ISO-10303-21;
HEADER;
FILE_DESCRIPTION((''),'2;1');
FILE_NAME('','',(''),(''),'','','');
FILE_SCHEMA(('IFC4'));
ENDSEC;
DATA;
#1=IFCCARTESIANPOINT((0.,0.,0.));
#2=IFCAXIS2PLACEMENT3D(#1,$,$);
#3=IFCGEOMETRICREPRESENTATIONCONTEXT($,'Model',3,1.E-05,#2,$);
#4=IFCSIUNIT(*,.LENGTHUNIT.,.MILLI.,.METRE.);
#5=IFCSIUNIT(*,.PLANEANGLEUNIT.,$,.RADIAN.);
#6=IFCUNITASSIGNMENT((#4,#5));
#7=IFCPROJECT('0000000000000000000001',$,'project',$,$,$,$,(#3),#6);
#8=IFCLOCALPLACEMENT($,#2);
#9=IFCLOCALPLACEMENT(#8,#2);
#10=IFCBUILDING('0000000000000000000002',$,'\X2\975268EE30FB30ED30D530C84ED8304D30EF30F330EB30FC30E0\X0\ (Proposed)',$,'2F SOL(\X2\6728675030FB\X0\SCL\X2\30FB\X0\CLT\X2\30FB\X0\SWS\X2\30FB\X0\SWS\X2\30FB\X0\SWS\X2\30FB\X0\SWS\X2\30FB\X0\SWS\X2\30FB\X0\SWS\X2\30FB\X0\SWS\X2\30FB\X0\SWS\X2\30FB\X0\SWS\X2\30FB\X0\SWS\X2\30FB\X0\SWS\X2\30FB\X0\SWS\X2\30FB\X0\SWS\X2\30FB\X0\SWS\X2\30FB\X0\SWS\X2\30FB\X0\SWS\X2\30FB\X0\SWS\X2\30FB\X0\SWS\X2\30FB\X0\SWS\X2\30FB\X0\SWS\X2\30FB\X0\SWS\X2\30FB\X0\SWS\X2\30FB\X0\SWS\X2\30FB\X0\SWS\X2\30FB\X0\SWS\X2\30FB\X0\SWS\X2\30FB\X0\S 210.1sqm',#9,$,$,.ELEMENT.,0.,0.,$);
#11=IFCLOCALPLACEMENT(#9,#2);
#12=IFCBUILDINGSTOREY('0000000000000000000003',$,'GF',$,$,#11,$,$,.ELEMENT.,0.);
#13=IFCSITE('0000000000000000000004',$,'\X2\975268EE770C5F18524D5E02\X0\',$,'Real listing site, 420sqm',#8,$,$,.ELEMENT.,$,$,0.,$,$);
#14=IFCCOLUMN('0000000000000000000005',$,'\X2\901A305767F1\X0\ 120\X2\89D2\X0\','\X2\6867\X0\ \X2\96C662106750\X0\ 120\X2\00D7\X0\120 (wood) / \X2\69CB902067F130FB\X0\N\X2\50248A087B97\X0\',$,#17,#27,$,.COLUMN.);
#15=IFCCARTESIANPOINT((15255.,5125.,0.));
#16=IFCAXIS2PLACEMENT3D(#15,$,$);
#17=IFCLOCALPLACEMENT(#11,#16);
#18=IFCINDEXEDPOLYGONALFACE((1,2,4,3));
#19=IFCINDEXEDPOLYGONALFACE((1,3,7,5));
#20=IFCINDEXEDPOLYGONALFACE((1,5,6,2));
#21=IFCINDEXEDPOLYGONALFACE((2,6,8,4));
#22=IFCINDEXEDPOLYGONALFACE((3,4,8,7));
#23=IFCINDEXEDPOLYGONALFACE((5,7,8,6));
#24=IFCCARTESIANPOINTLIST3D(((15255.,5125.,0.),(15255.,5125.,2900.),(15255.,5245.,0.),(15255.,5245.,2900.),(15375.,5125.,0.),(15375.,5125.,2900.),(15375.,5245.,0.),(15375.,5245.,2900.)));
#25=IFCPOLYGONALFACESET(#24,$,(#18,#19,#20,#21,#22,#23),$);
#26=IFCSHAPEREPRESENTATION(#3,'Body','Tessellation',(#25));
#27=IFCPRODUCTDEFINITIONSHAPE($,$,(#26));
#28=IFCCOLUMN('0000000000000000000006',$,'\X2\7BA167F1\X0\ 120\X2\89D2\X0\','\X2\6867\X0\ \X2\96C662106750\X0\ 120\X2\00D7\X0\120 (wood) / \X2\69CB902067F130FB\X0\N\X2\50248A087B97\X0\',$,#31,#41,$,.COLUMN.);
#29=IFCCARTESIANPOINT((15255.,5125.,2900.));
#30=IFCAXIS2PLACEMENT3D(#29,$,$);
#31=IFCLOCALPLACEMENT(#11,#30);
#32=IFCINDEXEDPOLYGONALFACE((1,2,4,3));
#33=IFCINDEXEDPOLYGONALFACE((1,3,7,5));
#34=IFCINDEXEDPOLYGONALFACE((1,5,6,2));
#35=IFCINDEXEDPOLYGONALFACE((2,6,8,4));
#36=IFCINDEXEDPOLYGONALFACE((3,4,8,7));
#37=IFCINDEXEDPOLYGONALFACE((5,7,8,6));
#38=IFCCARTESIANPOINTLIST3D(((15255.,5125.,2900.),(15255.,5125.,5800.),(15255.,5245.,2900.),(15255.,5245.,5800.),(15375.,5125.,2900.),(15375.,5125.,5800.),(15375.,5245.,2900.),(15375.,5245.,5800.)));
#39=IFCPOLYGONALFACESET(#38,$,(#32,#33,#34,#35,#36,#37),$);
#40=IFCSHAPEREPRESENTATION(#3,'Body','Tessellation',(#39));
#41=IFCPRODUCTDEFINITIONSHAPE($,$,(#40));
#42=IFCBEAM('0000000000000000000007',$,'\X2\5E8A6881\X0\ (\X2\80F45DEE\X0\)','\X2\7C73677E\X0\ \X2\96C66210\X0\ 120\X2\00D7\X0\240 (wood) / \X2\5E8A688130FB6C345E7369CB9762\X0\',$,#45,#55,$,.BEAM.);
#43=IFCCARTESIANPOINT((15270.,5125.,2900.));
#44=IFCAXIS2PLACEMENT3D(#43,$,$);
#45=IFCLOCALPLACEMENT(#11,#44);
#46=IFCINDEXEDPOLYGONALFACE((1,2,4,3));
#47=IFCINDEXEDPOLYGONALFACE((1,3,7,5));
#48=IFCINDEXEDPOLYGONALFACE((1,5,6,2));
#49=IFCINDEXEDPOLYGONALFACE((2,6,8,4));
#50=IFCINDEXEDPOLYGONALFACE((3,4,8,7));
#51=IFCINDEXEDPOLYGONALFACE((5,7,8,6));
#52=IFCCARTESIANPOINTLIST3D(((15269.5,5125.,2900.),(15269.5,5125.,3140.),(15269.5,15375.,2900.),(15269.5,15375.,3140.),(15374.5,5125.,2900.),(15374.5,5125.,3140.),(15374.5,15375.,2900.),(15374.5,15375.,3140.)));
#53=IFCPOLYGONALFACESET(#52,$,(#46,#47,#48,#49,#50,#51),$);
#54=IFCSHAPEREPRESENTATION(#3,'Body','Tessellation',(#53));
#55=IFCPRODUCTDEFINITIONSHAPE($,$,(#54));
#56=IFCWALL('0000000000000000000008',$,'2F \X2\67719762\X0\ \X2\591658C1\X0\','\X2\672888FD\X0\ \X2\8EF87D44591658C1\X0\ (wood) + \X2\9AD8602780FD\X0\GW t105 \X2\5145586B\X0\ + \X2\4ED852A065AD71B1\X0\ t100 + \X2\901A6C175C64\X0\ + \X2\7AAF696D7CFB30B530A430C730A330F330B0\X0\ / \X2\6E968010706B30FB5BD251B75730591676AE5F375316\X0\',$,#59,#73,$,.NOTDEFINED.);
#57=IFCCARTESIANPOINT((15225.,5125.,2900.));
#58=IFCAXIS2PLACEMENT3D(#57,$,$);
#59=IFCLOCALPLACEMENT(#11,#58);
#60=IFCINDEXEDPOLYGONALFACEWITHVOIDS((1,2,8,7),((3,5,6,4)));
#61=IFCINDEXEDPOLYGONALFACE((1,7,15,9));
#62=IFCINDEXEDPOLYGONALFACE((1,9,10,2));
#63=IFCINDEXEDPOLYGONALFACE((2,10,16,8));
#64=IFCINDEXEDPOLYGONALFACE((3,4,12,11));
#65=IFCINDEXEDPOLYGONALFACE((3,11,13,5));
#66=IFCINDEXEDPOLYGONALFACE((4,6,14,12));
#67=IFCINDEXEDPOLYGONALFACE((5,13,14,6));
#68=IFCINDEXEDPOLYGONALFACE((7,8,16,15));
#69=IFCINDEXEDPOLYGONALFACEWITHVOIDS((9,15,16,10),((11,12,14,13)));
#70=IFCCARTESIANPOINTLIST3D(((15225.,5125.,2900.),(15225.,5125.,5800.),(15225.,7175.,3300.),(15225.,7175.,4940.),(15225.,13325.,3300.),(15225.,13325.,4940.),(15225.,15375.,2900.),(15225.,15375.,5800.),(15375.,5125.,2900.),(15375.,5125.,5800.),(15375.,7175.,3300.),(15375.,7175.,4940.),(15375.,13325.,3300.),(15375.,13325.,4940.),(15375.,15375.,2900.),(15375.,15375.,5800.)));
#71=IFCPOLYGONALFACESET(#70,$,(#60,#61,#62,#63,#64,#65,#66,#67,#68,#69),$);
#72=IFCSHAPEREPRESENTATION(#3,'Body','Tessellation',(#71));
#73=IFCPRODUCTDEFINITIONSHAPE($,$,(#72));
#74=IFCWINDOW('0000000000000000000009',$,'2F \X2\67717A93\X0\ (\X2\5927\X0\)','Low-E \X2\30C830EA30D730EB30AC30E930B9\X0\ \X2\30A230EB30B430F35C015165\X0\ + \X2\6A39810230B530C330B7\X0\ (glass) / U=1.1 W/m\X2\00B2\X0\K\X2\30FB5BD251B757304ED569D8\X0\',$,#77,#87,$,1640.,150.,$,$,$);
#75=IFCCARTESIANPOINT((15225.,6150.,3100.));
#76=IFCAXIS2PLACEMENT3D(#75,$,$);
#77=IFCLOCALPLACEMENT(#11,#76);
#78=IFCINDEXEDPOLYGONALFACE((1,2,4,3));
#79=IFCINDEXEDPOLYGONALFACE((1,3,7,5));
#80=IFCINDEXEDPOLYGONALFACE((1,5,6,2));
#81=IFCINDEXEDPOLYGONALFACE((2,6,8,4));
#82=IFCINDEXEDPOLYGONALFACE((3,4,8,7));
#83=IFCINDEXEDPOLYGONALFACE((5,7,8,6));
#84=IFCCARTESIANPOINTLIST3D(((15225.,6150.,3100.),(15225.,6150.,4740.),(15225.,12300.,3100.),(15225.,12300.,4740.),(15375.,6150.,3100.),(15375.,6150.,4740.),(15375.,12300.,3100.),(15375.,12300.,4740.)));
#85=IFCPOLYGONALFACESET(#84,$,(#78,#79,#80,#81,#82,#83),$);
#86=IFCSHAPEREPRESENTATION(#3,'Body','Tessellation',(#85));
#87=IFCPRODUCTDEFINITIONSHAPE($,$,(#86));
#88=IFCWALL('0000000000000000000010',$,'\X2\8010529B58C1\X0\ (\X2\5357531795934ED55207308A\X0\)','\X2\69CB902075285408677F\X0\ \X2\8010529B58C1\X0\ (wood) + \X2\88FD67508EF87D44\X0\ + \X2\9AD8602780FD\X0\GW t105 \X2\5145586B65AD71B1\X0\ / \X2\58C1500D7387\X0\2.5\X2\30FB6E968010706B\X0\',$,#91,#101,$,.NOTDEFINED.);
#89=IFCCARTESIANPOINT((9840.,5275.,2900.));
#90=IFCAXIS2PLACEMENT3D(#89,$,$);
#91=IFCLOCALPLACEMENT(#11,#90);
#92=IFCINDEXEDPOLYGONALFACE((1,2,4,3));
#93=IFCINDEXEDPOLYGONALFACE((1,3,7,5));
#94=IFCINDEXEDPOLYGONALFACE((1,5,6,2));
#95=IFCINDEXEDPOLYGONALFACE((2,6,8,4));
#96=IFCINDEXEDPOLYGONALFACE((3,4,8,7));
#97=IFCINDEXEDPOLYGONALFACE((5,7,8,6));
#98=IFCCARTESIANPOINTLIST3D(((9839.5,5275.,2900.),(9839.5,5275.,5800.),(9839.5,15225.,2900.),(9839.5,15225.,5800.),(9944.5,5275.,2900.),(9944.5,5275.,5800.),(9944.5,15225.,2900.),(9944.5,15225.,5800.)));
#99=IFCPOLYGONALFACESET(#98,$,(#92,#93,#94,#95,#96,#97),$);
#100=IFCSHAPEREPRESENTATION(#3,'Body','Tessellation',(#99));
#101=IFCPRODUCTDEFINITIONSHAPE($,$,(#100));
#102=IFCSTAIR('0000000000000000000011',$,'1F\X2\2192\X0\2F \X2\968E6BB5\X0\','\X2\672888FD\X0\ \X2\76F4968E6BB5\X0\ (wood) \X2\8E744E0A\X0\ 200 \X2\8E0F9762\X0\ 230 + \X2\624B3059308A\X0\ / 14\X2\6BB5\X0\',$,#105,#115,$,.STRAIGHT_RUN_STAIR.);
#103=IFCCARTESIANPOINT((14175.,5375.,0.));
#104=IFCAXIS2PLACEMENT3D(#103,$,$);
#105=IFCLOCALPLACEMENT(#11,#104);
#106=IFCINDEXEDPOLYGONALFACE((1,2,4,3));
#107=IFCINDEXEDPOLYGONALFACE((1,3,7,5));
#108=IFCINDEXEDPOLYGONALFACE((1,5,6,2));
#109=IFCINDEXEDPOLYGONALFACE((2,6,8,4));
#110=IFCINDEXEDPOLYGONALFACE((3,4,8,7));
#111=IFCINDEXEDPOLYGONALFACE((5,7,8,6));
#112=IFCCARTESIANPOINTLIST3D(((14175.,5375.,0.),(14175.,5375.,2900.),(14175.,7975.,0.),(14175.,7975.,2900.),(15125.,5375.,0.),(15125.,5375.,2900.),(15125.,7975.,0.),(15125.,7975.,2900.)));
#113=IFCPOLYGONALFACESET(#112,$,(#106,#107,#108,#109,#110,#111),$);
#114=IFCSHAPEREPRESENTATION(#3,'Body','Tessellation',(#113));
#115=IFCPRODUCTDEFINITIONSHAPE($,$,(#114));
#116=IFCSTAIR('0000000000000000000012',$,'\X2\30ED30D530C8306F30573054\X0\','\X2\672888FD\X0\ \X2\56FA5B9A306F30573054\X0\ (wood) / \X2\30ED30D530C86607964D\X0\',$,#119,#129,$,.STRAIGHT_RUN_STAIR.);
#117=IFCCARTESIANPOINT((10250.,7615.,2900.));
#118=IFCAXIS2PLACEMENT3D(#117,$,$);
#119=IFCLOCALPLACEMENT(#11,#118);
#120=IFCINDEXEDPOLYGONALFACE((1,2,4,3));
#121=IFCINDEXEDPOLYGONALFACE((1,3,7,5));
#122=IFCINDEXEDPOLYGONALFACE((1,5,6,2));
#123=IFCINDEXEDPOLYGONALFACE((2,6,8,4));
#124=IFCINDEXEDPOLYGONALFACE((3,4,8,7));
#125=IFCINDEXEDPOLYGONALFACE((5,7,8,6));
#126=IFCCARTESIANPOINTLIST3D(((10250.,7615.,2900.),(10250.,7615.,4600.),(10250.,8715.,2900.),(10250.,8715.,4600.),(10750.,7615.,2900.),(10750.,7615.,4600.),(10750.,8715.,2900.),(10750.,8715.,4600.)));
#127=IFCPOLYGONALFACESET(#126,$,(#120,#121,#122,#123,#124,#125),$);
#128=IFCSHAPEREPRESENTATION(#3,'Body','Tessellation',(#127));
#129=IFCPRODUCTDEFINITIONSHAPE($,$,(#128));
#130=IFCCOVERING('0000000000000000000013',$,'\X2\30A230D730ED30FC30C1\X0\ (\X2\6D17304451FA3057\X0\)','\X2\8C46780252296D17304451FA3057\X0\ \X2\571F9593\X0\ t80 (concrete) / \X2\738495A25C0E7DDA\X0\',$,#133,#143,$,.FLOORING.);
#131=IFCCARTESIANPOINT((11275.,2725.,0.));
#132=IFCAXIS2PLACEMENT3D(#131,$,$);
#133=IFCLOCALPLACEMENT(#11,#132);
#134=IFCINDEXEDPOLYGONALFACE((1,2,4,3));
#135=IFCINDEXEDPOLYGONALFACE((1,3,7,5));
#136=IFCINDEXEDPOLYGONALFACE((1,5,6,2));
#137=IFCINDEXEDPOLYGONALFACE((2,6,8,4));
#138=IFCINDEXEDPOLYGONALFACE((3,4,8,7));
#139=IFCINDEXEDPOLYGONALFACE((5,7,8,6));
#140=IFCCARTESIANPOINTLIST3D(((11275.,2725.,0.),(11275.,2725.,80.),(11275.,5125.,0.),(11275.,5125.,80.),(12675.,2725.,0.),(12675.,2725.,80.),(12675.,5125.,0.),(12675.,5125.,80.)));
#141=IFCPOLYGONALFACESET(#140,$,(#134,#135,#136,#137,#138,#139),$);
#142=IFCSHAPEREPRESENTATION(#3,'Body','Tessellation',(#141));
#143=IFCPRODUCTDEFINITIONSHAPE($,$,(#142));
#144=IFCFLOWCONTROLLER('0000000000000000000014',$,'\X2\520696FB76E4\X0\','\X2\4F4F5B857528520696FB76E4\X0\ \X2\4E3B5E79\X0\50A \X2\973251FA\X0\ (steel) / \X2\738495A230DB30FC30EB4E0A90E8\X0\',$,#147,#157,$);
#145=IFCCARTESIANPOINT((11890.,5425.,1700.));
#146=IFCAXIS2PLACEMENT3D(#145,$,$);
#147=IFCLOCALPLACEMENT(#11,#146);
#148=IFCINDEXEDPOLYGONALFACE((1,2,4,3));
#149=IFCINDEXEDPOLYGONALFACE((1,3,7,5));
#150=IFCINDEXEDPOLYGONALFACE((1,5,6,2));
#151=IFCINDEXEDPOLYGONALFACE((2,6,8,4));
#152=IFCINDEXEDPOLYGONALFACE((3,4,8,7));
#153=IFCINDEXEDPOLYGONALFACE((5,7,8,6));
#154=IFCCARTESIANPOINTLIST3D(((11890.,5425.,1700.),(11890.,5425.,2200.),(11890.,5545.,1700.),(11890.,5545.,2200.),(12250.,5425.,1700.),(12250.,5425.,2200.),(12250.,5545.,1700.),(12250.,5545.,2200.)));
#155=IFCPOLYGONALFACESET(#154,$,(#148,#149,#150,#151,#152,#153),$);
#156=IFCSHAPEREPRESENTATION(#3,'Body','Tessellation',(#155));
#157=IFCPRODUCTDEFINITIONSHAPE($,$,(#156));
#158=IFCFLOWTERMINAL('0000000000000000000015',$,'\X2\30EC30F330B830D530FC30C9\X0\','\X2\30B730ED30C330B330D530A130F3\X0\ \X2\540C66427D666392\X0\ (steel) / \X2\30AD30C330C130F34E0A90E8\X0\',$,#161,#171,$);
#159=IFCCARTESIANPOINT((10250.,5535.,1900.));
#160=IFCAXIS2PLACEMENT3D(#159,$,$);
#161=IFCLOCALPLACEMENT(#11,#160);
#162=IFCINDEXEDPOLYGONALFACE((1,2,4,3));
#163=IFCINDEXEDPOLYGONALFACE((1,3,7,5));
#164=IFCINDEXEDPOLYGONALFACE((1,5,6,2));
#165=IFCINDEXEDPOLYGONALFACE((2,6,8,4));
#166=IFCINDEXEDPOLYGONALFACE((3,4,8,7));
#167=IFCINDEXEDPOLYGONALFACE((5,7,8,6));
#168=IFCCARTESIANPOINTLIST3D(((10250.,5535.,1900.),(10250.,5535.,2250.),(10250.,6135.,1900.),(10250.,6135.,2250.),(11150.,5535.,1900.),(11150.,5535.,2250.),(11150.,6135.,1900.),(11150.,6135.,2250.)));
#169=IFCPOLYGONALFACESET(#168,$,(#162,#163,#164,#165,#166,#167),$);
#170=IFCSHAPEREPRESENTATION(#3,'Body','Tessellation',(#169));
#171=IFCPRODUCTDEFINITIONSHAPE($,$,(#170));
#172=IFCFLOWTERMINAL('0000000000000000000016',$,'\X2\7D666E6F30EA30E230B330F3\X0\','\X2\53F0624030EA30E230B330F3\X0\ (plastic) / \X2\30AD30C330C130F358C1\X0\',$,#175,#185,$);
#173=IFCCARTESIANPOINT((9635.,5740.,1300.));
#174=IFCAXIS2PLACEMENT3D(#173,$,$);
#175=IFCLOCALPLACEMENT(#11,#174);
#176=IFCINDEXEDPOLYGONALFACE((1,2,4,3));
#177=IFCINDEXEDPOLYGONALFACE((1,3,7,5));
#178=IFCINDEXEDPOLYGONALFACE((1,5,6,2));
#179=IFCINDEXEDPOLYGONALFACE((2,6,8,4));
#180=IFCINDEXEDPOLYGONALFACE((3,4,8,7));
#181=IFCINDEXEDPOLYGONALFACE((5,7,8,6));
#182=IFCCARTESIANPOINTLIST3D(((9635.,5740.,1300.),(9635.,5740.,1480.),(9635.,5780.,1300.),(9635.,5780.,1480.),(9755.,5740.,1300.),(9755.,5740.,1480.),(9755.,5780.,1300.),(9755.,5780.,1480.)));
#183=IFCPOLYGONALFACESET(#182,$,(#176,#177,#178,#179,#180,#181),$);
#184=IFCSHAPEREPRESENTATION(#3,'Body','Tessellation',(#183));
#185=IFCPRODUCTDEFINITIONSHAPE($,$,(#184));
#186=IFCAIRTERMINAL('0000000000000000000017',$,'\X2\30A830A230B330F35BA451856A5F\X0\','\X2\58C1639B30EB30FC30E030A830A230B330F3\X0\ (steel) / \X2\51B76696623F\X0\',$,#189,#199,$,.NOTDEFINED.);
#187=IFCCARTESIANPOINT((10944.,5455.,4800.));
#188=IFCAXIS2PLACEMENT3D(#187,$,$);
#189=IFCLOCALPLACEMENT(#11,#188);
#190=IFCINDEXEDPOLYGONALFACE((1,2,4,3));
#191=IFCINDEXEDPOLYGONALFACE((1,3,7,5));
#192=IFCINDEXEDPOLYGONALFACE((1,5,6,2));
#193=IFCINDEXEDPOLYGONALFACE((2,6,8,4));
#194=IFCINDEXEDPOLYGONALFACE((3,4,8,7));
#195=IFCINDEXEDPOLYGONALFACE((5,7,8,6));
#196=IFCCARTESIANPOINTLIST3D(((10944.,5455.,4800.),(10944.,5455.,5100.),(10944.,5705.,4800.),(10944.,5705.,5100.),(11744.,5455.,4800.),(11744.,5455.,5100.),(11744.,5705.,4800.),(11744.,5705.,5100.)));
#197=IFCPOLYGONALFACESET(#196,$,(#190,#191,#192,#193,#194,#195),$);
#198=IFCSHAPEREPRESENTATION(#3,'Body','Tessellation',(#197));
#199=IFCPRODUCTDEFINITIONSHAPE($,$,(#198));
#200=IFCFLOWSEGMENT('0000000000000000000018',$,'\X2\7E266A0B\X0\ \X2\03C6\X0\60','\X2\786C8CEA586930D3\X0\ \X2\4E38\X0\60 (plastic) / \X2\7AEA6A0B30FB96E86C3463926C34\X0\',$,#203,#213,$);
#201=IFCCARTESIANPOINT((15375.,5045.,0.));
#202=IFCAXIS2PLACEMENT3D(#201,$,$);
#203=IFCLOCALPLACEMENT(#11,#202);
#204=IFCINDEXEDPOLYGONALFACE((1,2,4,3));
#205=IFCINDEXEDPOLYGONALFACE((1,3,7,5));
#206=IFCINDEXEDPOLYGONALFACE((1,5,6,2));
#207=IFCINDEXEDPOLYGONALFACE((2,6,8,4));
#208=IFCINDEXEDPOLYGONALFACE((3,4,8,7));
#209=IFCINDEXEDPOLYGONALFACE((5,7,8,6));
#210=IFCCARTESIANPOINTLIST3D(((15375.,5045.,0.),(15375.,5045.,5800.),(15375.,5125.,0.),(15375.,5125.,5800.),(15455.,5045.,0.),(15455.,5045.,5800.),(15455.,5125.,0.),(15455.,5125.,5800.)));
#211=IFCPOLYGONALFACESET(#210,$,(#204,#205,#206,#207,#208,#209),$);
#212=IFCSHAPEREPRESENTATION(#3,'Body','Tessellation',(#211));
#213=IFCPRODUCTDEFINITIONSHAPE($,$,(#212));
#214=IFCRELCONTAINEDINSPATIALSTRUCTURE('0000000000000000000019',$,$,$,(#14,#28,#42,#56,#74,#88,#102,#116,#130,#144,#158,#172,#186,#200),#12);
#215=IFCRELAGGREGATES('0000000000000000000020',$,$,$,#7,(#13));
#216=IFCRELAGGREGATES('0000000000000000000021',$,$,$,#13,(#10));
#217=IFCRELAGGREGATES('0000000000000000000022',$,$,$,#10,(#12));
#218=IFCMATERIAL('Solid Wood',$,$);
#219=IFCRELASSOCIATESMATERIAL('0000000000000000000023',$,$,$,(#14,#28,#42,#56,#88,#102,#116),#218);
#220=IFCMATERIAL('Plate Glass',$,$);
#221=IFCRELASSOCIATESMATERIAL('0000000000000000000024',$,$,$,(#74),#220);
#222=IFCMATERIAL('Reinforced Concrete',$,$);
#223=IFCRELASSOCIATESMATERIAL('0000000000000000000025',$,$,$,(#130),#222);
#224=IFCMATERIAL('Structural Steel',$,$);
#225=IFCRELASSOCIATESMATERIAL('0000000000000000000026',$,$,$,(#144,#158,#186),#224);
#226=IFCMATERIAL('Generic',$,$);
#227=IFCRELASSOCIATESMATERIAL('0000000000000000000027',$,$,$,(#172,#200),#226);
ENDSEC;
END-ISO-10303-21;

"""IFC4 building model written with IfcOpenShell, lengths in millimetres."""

from ifc_helpers import new_model, si_unit, frame, frame_2d, origin, place, context, project, spatial, rectangle, extrude, material, element, fill, save


model = new_model("IFC4")

# Units and contexts
model_context = context("Model", 3, precision=1e-05, world=origin())
ifc_project = project(units=[si_unit("LENGTHUNIT", "METRE", prefix="MILLI"), si_unit("PLANEANGLEUNIT", "RADIAN")], contexts=[model_context])

# Site, building, storey
site_placement = place(None, origin())
site = spatial("IfcSite", under=ifc_project, at=site_placement, Name="青森県弘前市", ObjectType="Real listing site, 420sqm", CompositionType="ELEMENT", RefElevation=0.0)
building_placement = place(site_placement, origin())
building = spatial("IfcBuilding", under=site, at=building_placement, Name="青森・ロフト付きワンルーム (Proposed)", ObjectType="2F SOL(木材・SCL・CLT・SWS・SWS・SWS・SWS・SWS・SWS・SWS・SWS・SWS・SWS・SWS・SWS・SWS・SWS・SWS・SWS・SWS・SWS・SWS・SWS・SWS・SWS・SWS・SWS・SWS・SWS・S 210.1sqm", CompositionType="ELEMENT", ElevationOfRefHeight=0.0, ElevationOfTerrain=0.0)
storey_placement = place(building_placement, origin())
storey = spatial("IfcBuildingStorey", under=building, at=storey_placement, Name="GF", CompositionType="ELEMENT", Elevation=0.0)

# Columns
ifc_material_1 = material(Name="Solid Wood")
column_1_placement = place(storey_placement, frame((15255.0, 5125.0, 0.0)))
element("IfcColumn", 1, at=column_1_placement, inside=storey, material=ifc_material_1, Name="通し柱 120角", Description="桧 集成材 120×120 (wood) / 構造柱・N値計算", PredefinedType="COLUMN", context=model_context, shape_type="SweptSolid", body=[
    extrude(rectangle(XDim=120.0, YDim=120.0, at=frame_2d((60.0, 60.0))), frame((15255.0, 5125.0, 0.0)), (0.0, 0.0, 1.0), 2900.0),
])
column_2_placement = place(storey_placement, frame((15255.0, 5125.0, 2900.0)))
element("IfcColumn", 2, at=column_2_placement, inside=storey, material=ifc_material_1, Name="管柱 120角", Description="桧 集成材 120×120 (wood) / 構造柱・N値計算", PredefinedType="COLUMN", context=model_context, shape_type="SweptSolid", body=[
    extrude(rectangle(XDim=120.0, YDim=120.0, at=frame_2d((60.0, 60.0))), frame((15255.0, 5125.0, 2900.0)), (0.0, 0.0, 1.0), 2900.0),
])

# Beam
beam_1_placement = place(storey_placement, frame((15270.0, 5125.0, 2900.0)))
element("IfcBeam", 3, at=beam_1_placement, inside=storey, material=ifc_material_1, Name="床梁 (胴差)", Description="米松 集成 120×240 (wood) / 床梁・水平構面", PredefinedType="BEAM", context=model_context, shape_type="SweptSolid", body=[
    extrude(rectangle(XDim=105.0, YDim=10250.0, at=frame_2d((52.0, 5125.0))), frame((15270.0, 5125.0, 2900.0)), (0.0, 0.0, 1.0), 240.0),
])

# Shared definitions
ifc_material_2 = material(Name="Plate Glass")

# Wall, opening, window
wall_1_placement = place(storey_placement, frame((15225.0, 5125.0, 2900.0)))
wall_1 = element("IfcWall", 4, at=wall_1_placement, inside=storey, material=ifc_material_1, Name="2F 東面 外壁", Description="木製 軸組外壁 (wood) + 高性能GW t105 充填 + 付加断熱 t100 + 通気層 + 窯業系サイディング / 準耐火・寒冷地外皮強化", PredefinedType="NOTDEFINED", context=model_context, shape_type="SweptSolid", body=[
    extrude(rectangle(XDim=150.0, YDim=10250.0, at=frame_2d((75.0, 5125.0))), frame((15225.0, 5125.0, 2900.0)), (0.0, 0.0, 1.0), 2900.0),
])
opening_1_placement = place(storey_placement, frame((15225.0, 6150.0, 3100.0)))
opening_1 = element("IfcOpeningElement", 5, at=opening_1_placement, cuts=wall_1, PredefinedType="NOTDEFINED", context=model_context, shape_type="SweptSolid", body=[
    extrude(rectangle(XDim=150.0, YDim=6150.0, at=frame_2d((75.0, 3075.0))), frame((15225.0, 6150.0, 3100.0)), (0.0, 0.0, 1.0), 1640.0),
])
window_1_placement = place(storey_placement, frame((15225.0, 6150.0, 3100.0)))
window_1 = element("IfcWindow", 6, at=window_1_placement, inside=storey, material=ifc_material_2, Name="2F 東窓 (大)", Description="Low-E トリプルガラス アルゴン封入 + 樹脂サッシ (glass) / U=1.1 W/m²K・寒冷地仕様", OverallHeight=1640.0, OverallWidth=150.0, context=model_context, shape_type="SweptSolid", body=[
    extrude(rectangle(XDim=150.0, YDim=6150.0, at=frame_2d((75.0, 3075.0))), frame((15225.0, 6150.0, 3100.0)), (0.0, 0.0, 1.0), 1640.0),
])
fill(opening_1, window_1)

# Wall
wall_2_placement = place(storey_placement, frame((9840.0, 5275.0, 2900.0)))
element("IfcWall", 7, at=wall_2_placement, inside=storey, material=ifc_material_1, Name="耐力壁 (南北間仕切り)", Description="構造用合板 耐力壁 (wood) + 製材軸組 + 高性能GW t105 充填断熱 / 壁倍率2.5・準耐火", PredefinedType="NOTDEFINED", context=model_context, shape_type="SweptSolid", body=[
    extrude(rectangle(XDim=105.0, YDim=9950.0, at=frame_2d((52.0, 4975.0))), frame((9840.0, 5275.0, 2900.0)), (0.0, 0.0, 1.0), 2900.0),
])

# Stairs
stair_1_placement = place(storey_placement, frame((14175.0, 5375.0, 0.0)))
element("IfcStair", 8, at=stair_1_placement, inside=storey, material=ifc_material_1, Name="1F→2F 階段", Description="木製 直階段 (wood) 蹴上 200 踏面 230 + 手すり / 14段", PredefinedType="STRAIGHT_RUN_STAIR", context=model_context, shape_type="SweptSolid", body=[
    extrude(rectangle(XDim=950.0, YDim=2600.0, at=frame_2d((475.0, 1300.0))), frame((14175.0, 5375.0, 0.0)), (0.0, 0.0, 1.0), 2900.0),
])
stair_2_placement = place(storey_placement, frame((10250.0, 7615.0, 2900.0)))
element("IfcStair", 9, at=stair_2_placement, inside=storey, material=ifc_material_1, Name="ロフトはしご", Description="木製 固定はしご (wood) / ロフト昇降", PredefinedType="STRAIGHT_RUN_STAIR", context=model_context, shape_type="SweptSolid", body=[
    extrude(rectangle(XDim=500.0, YDim=1100.0, at=frame_2d((250.0, 550.0))), frame((10250.0, 7615.0, 2900.0)), (0.0, 0.0, 1.0), 1700.0),
])

# Covering
ifc_material_3 = material(Name="Reinforced Concrete")
covering_placement = place(storey_placement, frame((11275.0, 2725.0, 0.0)))
element("IfcCovering", 10, at=covering_placement, inside=storey, material=ifc_material_3, Name="アプローチ (洗い出し)", Description="豆砂利洗い出し 土間 t80 (concrete) / 玄関導線", PredefinedType="FLOORING", context=model_context, shape_type="SweptSolid", body=[
    extrude(rectangle(XDim=1400.0, YDim=2400.0, at=frame_2d((700.0, 1200.0))), frame((11275.0, 2725.0, 0.0)), (0.0, 0.0, 1.0), 80.0),
])

# Flow controller
ifc_material_4 = material(Name="Structural Steel")
flow_controller_placement = place(storey_placement, frame((11890.0, 5425.0, 1700.0)))
element("IfcFlowController", 11, at=flow_controller_placement, inside=storey, material=ifc_material_4, Name="分電盤", Description="住宅用分電盤 主幹50A 露出 (steel) / 玄関ホール上部", context=model_context, shape_type="SweptSolid", body=[
    extrude(rectangle(XDim=360.0, YDim=120.0, at=frame_2d((180.0, 60.0))), frame((11890.0, 5425.0, 1700.0)), (0.0, 0.0, 1.0), 500.0),
])

# Flow terminals
flow_terminal_1_placement = place(storey_placement, frame((10250.0, 5535.0, 1900.0)))
element("IfcFlowTerminal", 12, at=flow_terminal_1_placement, inside=storey, material=ifc_material_4, Name="レンジフード", Description="シロッコファン 同時給排 (steel) / キッチン上部", context=model_context, shape_type="SweptSolid", body=[
    extrude(rectangle(XDim=900.0, YDim=600.0, at=frame_2d((450.0, 300.0))), frame((10250.0, 5535.0, 1900.0)), (0.0, 0.0, 1.0), 350.0),
])
ifc_material_5 = material(Name="Generic")
flow_terminal_2_placement = place(storey_placement, frame((9635.0, 5740.0, 1300.0)))
element("IfcFlowTerminal", 13, at=flow_terminal_2_placement, inside=storey, material=ifc_material_5, Name="給湯リモコン", Description="台所リモコン (plastic) / キッチン壁", context=model_context, shape_type="SweptSolid", body=[
    extrude(rectangle(XDim=120.0, YDim=40.0, at=frame_2d((60.0, 20.0))), frame((9635.0, 5740.0, 1300.0)), (0.0, 0.0, 1.0), 180.0),
])

# Air terminal
air_terminal_placement = place(storey_placement, frame((10944.0, 5455.0, 4800.0)))
element("IfcAirTerminal", 14, at=air_terminal_placement, inside=storey, material=ifc_material_4, Name="エアコン室内機", Description="壁掛ルームエアコン (steel) / 冷暖房", PredefinedType="NOTDEFINED", context=model_context, shape_type="SweptSolid", body=[
    extrude(rectangle(XDim=800.0, YDim=250.0, at=frame_2d((400.0, 125.0))), frame((10944.0, 5455.0, 4800.0)), (0.0, 0.0, 1.0), 300.0),
])

# Flow segment
flow_segment_placement = place(storey_placement, frame((15375.0, 5045.0, 0.0)))
element("IfcFlowSegment", 15, at=flow_segment_placement, inside=storey, material=ifc_material_5, Name="縦樋 φ60", Description="硬質塩ビ 丸60 (plastic) / 竪樋・雨水排水", context=model_context, shape_type="SweptSolid", body=[
    extrude(rectangle(XDim=80.0, YDim=80.0, at=frame_2d((40.0, 40.0))), frame((15375.0, 5045.0, 0.0)), (0.0, 0.0, 1.0), 5800.0),
])

save(model, "model.ifc")
